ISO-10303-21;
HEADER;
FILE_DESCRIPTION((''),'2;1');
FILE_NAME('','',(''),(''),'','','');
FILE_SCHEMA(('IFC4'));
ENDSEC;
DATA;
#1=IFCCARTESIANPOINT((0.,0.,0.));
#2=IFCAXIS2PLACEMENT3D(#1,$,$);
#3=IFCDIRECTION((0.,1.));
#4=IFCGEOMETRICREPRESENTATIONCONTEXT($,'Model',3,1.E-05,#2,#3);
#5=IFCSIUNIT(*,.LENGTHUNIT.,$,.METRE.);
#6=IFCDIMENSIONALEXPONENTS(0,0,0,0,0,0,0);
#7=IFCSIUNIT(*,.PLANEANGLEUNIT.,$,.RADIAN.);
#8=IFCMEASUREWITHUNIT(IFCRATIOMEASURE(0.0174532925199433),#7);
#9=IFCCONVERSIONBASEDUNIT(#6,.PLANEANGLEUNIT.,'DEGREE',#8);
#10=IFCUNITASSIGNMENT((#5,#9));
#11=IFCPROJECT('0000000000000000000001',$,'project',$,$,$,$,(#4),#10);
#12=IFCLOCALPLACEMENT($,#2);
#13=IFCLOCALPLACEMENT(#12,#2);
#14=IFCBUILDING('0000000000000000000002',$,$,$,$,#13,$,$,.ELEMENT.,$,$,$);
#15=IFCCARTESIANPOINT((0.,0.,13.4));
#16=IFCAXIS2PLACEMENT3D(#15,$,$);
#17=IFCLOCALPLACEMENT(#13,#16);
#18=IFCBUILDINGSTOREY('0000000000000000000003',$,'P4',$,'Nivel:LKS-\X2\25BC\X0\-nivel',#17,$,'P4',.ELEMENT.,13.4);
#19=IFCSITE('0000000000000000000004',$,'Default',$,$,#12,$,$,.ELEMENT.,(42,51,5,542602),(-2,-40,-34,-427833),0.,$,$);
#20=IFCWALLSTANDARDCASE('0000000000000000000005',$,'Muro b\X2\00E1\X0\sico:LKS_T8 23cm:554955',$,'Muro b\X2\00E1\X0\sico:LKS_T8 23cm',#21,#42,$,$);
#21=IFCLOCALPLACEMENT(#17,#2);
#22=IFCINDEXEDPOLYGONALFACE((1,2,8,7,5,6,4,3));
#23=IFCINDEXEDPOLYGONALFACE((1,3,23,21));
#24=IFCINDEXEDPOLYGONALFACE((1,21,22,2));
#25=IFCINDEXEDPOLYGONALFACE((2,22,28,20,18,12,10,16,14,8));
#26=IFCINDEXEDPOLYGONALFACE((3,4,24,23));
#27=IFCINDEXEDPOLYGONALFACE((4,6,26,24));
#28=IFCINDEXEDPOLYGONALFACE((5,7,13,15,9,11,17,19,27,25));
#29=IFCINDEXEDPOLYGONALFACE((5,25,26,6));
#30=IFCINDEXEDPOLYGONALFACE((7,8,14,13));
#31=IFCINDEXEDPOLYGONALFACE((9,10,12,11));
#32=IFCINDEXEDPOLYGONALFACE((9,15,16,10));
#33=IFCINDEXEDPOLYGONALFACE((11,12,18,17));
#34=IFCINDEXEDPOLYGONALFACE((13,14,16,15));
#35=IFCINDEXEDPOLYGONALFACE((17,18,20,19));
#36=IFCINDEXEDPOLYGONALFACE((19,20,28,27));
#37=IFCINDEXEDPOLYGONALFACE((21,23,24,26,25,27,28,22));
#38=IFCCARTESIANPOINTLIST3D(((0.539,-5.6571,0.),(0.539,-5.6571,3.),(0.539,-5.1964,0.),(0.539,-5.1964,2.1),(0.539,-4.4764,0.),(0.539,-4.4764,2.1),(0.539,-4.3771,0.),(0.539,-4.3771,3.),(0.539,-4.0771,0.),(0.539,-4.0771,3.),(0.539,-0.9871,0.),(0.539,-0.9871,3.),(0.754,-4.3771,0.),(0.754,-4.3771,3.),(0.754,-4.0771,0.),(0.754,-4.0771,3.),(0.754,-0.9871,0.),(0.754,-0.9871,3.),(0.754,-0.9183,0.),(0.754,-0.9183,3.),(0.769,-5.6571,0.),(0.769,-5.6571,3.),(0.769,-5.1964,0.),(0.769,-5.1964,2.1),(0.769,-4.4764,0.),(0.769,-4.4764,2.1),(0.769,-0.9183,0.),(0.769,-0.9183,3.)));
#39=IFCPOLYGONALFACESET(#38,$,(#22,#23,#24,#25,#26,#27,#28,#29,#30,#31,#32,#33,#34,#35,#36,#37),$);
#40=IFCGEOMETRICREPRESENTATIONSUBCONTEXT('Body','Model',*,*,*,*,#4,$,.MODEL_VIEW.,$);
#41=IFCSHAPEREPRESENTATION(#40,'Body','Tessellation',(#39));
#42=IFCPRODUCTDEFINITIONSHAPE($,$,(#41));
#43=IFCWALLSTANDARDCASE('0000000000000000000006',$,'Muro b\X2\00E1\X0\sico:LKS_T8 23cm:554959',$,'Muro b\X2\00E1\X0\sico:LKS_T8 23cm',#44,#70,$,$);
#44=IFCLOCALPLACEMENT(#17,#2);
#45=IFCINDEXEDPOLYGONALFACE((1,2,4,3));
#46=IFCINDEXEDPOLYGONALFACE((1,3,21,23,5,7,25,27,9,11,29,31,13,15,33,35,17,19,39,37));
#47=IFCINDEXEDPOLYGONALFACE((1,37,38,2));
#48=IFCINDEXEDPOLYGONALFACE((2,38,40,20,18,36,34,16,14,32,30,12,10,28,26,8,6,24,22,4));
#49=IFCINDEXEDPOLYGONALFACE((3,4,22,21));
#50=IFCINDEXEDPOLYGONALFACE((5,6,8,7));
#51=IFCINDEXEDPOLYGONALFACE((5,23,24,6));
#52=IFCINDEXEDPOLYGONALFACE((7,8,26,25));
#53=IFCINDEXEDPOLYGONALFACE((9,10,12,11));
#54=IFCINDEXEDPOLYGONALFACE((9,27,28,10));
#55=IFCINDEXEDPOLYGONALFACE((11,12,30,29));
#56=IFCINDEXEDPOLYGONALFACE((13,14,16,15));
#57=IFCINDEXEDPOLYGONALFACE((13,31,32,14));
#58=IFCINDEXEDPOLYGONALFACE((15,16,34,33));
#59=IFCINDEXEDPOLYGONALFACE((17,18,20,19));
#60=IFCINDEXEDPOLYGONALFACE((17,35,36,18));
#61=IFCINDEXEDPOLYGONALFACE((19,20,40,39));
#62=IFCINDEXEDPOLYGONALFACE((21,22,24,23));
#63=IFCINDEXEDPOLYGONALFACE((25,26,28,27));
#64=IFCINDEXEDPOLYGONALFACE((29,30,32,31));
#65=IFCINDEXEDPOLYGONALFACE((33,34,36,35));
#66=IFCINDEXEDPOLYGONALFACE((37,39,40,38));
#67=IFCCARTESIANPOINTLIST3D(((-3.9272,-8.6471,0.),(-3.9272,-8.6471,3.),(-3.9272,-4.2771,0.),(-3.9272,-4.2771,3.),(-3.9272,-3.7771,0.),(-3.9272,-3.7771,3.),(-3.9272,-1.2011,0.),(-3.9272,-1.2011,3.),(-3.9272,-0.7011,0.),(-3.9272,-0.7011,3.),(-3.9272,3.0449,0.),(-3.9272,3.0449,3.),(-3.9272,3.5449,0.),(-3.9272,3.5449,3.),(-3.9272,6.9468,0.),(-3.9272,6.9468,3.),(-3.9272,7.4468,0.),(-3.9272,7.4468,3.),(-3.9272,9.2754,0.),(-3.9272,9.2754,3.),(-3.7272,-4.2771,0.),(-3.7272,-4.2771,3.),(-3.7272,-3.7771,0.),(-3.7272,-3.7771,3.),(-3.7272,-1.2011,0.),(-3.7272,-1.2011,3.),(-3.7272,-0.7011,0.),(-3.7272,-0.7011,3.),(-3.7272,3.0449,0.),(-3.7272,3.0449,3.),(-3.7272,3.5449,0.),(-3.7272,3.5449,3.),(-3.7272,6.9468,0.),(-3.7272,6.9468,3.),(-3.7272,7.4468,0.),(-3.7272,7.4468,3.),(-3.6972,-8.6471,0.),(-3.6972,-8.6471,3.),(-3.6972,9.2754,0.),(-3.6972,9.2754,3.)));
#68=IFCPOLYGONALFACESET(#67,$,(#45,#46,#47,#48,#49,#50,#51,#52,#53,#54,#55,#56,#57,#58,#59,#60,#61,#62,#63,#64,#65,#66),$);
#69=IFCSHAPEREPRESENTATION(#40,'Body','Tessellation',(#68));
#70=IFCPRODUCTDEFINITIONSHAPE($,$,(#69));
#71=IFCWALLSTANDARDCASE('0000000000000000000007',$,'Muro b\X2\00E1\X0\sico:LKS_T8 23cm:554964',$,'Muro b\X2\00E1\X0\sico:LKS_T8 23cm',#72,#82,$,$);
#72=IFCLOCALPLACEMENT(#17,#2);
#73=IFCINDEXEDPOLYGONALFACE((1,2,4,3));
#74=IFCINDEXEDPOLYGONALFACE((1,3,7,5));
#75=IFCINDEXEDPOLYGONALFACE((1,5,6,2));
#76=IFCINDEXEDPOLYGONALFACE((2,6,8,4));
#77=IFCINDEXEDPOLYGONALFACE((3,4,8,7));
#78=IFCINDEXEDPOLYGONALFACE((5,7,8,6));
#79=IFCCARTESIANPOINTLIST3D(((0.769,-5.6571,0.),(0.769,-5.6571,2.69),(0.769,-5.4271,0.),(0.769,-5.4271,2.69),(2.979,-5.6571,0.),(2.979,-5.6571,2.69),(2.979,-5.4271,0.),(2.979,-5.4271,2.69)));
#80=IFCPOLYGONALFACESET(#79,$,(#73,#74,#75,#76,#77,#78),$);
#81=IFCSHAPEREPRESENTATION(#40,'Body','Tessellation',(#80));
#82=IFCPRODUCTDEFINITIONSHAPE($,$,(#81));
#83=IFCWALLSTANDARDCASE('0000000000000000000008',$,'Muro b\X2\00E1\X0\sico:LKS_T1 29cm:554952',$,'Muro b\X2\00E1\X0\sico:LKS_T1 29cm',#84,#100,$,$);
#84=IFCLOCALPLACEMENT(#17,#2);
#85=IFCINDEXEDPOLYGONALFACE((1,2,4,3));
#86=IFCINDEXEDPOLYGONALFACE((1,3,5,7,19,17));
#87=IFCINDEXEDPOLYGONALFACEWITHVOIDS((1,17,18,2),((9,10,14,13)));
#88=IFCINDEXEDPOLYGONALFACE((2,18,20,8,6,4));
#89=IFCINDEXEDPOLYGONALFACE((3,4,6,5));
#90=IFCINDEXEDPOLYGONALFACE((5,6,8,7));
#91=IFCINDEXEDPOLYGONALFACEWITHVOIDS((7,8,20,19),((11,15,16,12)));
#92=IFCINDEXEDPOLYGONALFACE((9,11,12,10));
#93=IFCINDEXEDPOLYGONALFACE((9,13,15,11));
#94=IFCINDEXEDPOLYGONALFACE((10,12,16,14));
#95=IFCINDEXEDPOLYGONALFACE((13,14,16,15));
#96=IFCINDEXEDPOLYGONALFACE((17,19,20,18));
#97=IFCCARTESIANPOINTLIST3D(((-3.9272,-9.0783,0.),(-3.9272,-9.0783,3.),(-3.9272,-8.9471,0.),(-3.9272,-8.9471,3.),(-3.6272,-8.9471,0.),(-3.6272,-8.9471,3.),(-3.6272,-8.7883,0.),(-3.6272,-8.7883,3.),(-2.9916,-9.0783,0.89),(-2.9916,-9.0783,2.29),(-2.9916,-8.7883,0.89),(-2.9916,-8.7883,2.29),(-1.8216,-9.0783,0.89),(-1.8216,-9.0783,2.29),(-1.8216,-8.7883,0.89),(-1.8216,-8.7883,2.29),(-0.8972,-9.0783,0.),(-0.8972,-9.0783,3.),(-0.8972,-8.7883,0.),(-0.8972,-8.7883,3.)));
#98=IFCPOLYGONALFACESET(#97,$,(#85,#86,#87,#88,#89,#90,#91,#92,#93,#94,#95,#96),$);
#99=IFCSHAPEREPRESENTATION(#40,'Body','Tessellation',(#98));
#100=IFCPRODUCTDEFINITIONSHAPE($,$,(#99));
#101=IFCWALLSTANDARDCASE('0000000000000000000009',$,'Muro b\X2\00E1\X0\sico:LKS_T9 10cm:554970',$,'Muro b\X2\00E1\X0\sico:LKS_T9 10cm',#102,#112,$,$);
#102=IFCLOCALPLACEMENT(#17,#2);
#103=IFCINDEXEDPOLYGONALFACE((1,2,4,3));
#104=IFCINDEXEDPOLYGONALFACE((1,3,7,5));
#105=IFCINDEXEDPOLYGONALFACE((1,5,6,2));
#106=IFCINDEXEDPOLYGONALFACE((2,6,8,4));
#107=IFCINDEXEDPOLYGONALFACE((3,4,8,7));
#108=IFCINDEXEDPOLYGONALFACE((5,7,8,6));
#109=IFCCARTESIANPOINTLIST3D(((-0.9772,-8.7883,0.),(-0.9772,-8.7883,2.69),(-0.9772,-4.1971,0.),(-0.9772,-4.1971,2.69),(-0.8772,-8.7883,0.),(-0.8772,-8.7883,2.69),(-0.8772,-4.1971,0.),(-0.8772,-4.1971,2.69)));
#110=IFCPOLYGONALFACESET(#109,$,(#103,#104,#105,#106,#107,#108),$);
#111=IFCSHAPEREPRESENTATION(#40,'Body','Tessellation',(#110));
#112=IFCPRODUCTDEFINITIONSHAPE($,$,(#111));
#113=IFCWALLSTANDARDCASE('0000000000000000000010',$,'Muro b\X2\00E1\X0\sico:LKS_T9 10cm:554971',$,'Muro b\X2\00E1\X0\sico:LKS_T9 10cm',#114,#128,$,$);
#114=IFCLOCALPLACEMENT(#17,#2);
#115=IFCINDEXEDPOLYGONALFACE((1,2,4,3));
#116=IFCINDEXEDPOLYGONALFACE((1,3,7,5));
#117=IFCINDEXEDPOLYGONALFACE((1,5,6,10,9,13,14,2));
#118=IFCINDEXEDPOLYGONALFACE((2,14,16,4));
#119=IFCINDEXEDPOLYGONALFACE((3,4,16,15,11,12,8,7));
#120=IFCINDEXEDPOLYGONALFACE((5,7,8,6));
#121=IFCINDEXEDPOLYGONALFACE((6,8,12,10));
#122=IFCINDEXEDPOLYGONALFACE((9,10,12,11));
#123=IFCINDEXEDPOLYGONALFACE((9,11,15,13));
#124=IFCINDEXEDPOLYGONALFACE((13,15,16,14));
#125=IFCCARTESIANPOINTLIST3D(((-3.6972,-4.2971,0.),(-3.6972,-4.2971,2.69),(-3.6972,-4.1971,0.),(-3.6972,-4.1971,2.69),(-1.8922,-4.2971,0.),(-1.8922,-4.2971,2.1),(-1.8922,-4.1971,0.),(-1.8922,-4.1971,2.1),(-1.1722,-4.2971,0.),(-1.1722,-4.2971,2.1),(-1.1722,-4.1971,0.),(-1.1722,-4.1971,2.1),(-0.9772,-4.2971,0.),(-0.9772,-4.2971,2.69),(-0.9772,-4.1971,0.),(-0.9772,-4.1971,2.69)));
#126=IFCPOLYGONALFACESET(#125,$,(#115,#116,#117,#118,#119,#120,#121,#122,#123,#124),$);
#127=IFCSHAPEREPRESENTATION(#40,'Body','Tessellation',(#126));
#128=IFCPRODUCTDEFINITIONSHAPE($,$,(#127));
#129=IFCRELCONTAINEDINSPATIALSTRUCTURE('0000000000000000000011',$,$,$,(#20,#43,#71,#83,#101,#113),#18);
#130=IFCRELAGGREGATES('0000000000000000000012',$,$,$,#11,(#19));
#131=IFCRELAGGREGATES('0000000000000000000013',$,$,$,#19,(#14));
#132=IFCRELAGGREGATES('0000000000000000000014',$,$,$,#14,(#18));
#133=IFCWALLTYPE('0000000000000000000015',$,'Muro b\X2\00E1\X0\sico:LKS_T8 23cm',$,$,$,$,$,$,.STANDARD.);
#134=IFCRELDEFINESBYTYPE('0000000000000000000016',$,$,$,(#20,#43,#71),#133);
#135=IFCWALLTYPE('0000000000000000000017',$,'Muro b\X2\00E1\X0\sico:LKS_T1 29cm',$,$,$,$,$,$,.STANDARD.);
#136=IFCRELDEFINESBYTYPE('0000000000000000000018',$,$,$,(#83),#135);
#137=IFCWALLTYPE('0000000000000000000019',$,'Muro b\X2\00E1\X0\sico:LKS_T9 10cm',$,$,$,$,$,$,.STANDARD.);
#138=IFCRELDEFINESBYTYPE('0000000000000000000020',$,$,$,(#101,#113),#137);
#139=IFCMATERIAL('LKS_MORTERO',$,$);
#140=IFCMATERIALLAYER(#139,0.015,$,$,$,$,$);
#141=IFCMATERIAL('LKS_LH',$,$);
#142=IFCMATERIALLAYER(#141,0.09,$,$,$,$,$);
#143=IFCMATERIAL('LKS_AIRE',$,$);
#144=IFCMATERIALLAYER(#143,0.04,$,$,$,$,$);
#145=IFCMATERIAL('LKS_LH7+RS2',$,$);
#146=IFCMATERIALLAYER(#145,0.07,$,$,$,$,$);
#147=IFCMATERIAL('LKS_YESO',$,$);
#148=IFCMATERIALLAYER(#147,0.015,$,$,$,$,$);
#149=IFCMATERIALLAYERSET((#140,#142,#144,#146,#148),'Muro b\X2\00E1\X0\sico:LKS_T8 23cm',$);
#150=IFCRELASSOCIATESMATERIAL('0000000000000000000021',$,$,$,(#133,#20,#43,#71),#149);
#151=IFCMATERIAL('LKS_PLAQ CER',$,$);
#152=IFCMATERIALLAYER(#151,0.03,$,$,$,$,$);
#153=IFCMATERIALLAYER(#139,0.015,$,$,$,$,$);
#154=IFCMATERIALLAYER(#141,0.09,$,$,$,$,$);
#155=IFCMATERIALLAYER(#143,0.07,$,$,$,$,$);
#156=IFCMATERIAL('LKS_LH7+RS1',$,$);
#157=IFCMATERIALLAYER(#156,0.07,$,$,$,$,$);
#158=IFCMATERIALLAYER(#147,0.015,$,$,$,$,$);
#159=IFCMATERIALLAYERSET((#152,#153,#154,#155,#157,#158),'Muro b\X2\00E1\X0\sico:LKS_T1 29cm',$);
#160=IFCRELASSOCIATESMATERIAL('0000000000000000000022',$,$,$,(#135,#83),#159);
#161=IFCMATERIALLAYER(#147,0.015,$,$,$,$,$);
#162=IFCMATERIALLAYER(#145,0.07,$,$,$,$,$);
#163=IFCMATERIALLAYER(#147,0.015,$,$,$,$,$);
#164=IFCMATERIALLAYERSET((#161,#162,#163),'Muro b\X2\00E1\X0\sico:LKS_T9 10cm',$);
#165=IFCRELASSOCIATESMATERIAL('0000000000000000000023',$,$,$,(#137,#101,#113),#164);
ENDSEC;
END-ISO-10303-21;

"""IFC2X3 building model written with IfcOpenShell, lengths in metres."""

from ifc_helpers import new_model, entity, si_unit, converted_unit, direction, frame, frame_2d, origin, place, context, subcontext, project, spatial, polyline, rectangle, extrude, clip, bounded_halfspace, material, layer, layer_set, layer_usage, type_object, element, save


model = new_model("IFC2X3")

# Units and contexts
model_context = context("Model", 3, precision=1e-05, world=origin(), true_north=direction((0.0, 1.0)))
body_context = subcontext(model_context, "Body", "Model", "MODEL_VIEW")
ifc_project = project(units=[si_unit("LENGTHUNIT", "METRE"), converted_unit("PLANEANGLEUNIT", "DEGREE", entity("IfcRatioMeasure", 0.0174532925199433), si_unit("PLANEANGLEUNIT", "RADIAN"), dimensions=[0, 0, 0, 0, 0, 0, 0])], contexts=[model_context])

# Site, building, storey
site_placement = place(None, origin())
site = spatial("IfcSite", under=ifc_project, at=site_placement, Name="Default", CompositionType="ELEMENT", RefLatitude=(42, 51, 5, 542602), RefLongitude=(-2, -40, -34, -427833), RefElevation=0.0)
building_placement = place(site_placement, origin())
building = spatial("IfcBuilding", under=site, at=building_placement, CompositionType="ELEMENT")
storey_placement = place(building_placement, frame((0.0, 0.0, 13.4)))
storey = spatial("IfcBuildingStorey", under=building, at=storey_placement, Name="P4", ObjectType="Nivel:LKS-▼-nivel", LongName="P4", CompositionType="ELEMENT", Elevation=13.4)

# Shared definitions
ifc_material_1 = material(Name="LKS_MORTERO")
ifc_layer_1 = layer(ifc_material_1, 0.015)
ifc_material_2 = material(Name="LKS_LH")
ifc_layer_2 = layer(ifc_material_2, 0.09)
ifc_material_3 = material(Name="LKS_AIRE")
ifc_layer_3 = layer(ifc_material_3, 0.04)
ifc_material_4 = material(Name="LKS_LH7+RS2")
ifc_layer_4 = layer(ifc_material_4, 0.07)
ifc_material_5 = material(Name="LKS_YESO")
ifc_layer_5 = layer(ifc_material_5, 0.015)
ifc_layer_set_1 = layer_set([ifc_layer_1, ifc_layer_2, ifc_layer_3, ifc_layer_4, ifc_layer_5], Name="Muro básico:LKS_T8 23cm")
wall_type_1 = type_object("IfcWallType", Name="Muro básico:LKS_T8 23cm", PredefinedType="STANDARD", material=ifc_layer_set_1)

# Walls, openings
ifc_layer_usage_1 = layer_usage(ifc_layer_set_1, "AXIS2", "POSITIVE", -0.115)
wall_1_placement = place(storey_placement, frame((0.654, -5.6571, 0.0), z_axis=(0.0, 0.0, 1.0), x_axis=(0.0, 1.0, 0.0)))
wall_1 = element("IfcWallStandardCase", 1, at=wall_1_placement, inside=storey, type_object=wall_type_1, material=ifc_layer_usage_1, Name="Muro básico:LKS_T8 23cm:554955", ObjectType="Muro básico:LKS_T8 23cm", context=body_context, shape_type="Clipping", body=[
    clip(clip(extrude(rectangle(XDim=4.7389, YDim=0.23, at=frame_2d((2.3694, 0.0), x_axis=(-1.0, 0.0))), origin(), (0.0, 0.0, 1.0), 3.0), bounded_halfspace(frame((4.67, -0.1, 0.0), z_axis=(0.0, -1.0, 0.0), x_axis=(0.0, 0.0, -1.0)), True, frame((4.67, -0.1, 0.0), z_axis=(0.0, -1.0, 0.0), x_axis=(0.0, 0.0, -1.0)), polyline([(0.0, 0.0), (0.0, 0.0689), (-1.5, 0.0689), (-3.0, 0.0689), (-3.0, 0.0), (0.0, 0.0)]))), bounded_halfspace(frame((4.67, -0.1, 3.0), z_axis=(-1.0, 0.0, 0.0), x_axis=(0.0, 0.0, -1.0)), True, frame((4.67, -0.1, 3.0), z_axis=(-1.0, 0.0, 0.0), x_axis=(0.0, 0.0, -1.0)), polyline([(0.0, 0.0), (0.0, -0.015), (0.0, -0.215), (3.0, -0.215), (3.0, 0.0), (0.0, 0.0)]))),
])
opening_1_placement = place(storey_placement, frame((0.654, -5.6571, 0.0), z_axis=(0.0, 0.0, 1.0), x_axis=(0.0, 1.0, 0.0)))
element("IfcOpeningElement", 2, at=opening_1_placement, cuts=wall_1, ObjectType="Opening", context=body_context, shape_type="SweptSolid", body=[
    extrude(rectangle(XDim=3.0, YDim=0.215, at=frame_2d((0.234, 0.0215), x_axis=(1.0, 0.0))), frame((1.28, -0.014, 1.734), z_axis=(1.0, 0.0, 0.0), x_axis=(0.0, 0.0, -1.0)), (0.0, 0.0, 1.0), 0.3),
])
opening_2_placement = place(wall_1_placement, frame((0.4608, -0.115, 0.0)))
element("IfcOpeningElement", 3, at=opening_2_placement, cuts=wall_1, ObjectType="Opening", context=body_context, shape_type="SweptSolid", body=[
    extrude(rectangle(XDim=2.1, YDim=0.72, at=frame_2d((1.05, 0.36), x_axis=(1.0, 0.0))), frame((0.0, 0.0, 0.0), z_axis=(0.0, 1.0, 0.0), x_axis=(0.0, 0.0, 1.0)), (0.0, 0.0, 1.0), 0.23),
])
ifc_layer_usage_2 = layer_usage(ifc_layer_set_1, "AXIS2", "NEGATIVE", 0.115)
wall_2_placement = place(storey_placement, frame((-3.8122, -8.6471, 0.0), z_axis=(0.0, 0.0, 1.0), x_axis=(0.0, 1.0, 0.0)))
wall_2 = element("IfcWallStandardCase", 4, at=wall_2_placement, inside=storey, type_object=wall_type_1, material=ifc_layer_usage_2, Name="Muro básico:LKS_T8 23cm:554959", ObjectType="Muro básico:LKS_T8 23cm", context=body_context, shape_type="Clipping", body=[
    clip(extrude(rectangle(XDim=17.9225, YDim=0.23, at=frame_2d((8.9613, 0.0), x_axis=(-1.0, 0.0))), origin(), (0.0, 0.0, 1.0), 3.0), bounded_halfspace(frame((0.0, -0.115, 0.0), z_axis=(1.0, 0.0, 0.0), x_axis=(0.0, 0.0, -1.0)), True, frame((0.0, -0.115, 0.0), z_axis=(1.0, 0.0, 0.0), x_axis=(0.0, 0.0, -1.0)), polyline([(0.0, 0.0), (0.0, 0.23), (-2.67, 0.23), (-3.0, 0.23), (-3.0, 0.0), (0.0, 0.0)]))),
])
opening_3_placement = place(storey_placement, frame((-3.8122, -8.6471, 0.0), z_axis=(0.0, 0.0, 1.0), x_axis=(0.0, 1.0, 0.0)))
element("IfcOpeningElement", 5, at=opening_3_placement, cuts=wall_2, ObjectType="Opening", context=body_context, shape_type="SweptSolid", body=[
    extrude(rectangle(XDim=3.0, YDim=0.2, at=frame_2d((0.39, 0.0), x_axis=(1.0, 0.0))), frame((4.37, 0.015, 1.89), z_axis=(1.0, 0.0, 0.0), x_axis=(0.0, 0.0, -1.0)), (0.0, 0.0, 1.0), 0.5),
])
opening_4_placement = place(storey_placement, frame((-3.8122, -8.6471, 0.0), z_axis=(0.0, 0.0, 1.0), x_axis=(0.0, 1.0, 0.0)))
element("IfcOpeningElement", 6, at=opening_4_placement, cuts=wall_2, ObjectType="Opening", context=body_context, shape_type="SweptSolid", body=[
    extrude(rectangle(XDim=3.0, YDim=0.2, at=frame_2d((0.39, 0.0), x_axis=(1.0, 0.0))), frame((7.446, 0.015, 1.89), z_axis=(1.0, 0.0, 0.0), x_axis=(0.0, 0.0, -1.0)), (0.0, 0.0, 1.0), 0.5),
])
opening_5_placement = place(storey_placement, frame((-3.8122, -8.6471, 0.0), z_axis=(0.0, 0.0, 1.0), x_axis=(0.0, 1.0, 0.0)))
element("IfcOpeningElement", 7, at=opening_5_placement, cuts=wall_2, ObjectType="Opening", context=body_context, shape_type="SweptSolid", body=[
    extrude(rectangle(XDim=3.0, YDim=0.2, at=frame_2d((0.39, 0.0), x_axis=(1.0, 0.0))), frame((11.692, 0.015, 1.89), z_axis=(1.0, 0.0, 0.0), x_axis=(0.0, 0.0, -1.0)), (0.0, 0.0, 1.0), 0.5),
])
opening_6_placement = place(storey_placement, frame((-3.8122, -8.6471, 0.0), z_axis=(0.0, 0.0, 1.0), x_axis=(0.0, 1.0, 0.0)))
element("IfcOpeningElement", 8, at=opening_6_placement, cuts=wall_2, ObjectType="Opening", context=body_context, shape_type="SweptSolid", body=[
    extrude(rectangle(XDim=3.0, YDim=0.2, at=frame_2d((0.39, 0.0), x_axis=(1.0, 0.0))), frame((15.5939, 0.015, 1.89), z_axis=(1.0, 0.0, 0.0), x_axis=(0.0, 0.0, -1.0)), (0.0, 0.0, 1.0), 0.5),
])

# Wall
ifc_layer_usage_3 = layer_usage(ifc_layer_set_1, "AXIS2", "POSITIVE", -0.115)
wall_3_placement = place(storey_placement, frame((2.979, -5.5421, 0.0), z_axis=(0.0, 0.0, 1.0), x_axis=(-1.0, 0.0, 0.0)))
element("IfcWallStandardCase", 9, at=wall_3_placement, inside=storey, type_object=wall_type_1, material=ifc_layer_usage_3, Name="Muro básico:LKS_T8 23cm:554964", ObjectType="Muro básico:LKS_T8 23cm", context=body_context, shape_type="SweptSolid", body=[
    extrude(rectangle(XDim=2.21, YDim=0.23, at=frame_2d((1.105, 0.0), x_axis=(-1.0, 0.0))), origin(), (0.0, 0.0, 1.0), 2.69),
])

# Wall, opening
ifc_material_6 = material(Name="LKS_PLAQ CER")
ifc_layer_6 = layer(ifc_material_6, 0.03)
ifc_layer_7 = layer(ifc_material_1, 0.015)
ifc_layer_8 = layer(ifc_material_2, 0.09)
ifc_layer_9 = layer(ifc_material_3, 0.07)
ifc_material_7 = material(Name="LKS_LH7+RS1")
ifc_layer_10 = layer(ifc_material_7, 0.07)
ifc_layer_11 = layer(ifc_material_5, 0.015)
ifc_layer_set_2 = layer_set([ifc_layer_6, ifc_layer_7, ifc_layer_8, ifc_layer_9, ifc_layer_10, ifc_layer_11], Name="Muro básico:LKS_T1 29cm")
ifc_layer_usage_4 = layer_usage(ifc_layer_set_2, "AXIS2", "POSITIVE", -0.145)
wall_type_2 = type_object("IfcWallType", Name="Muro básico:LKS_T1 29cm", PredefinedType="STANDARD", material=ifc_layer_set_2)
wall_4_placement = place(storey_placement, frame((-3.9272, -8.9333, 0.0)))
wall_4 = element("IfcWallStandardCase", 10, at=wall_4_placement, inside=storey, type_object=wall_type_2, material=ifc_layer_usage_4, Name="Muro básico:LKS_T1 29cm:554952", ObjectType="Muro básico:LKS_T1 29cm", context=body_context, shape_type="Clipping", body=[
    clip(clip(extrude(rectangle(XDim=3.03, YDim=0.29, at=frame_2d((1.515, 0.0), x_axis=(-1.0, 0.0))), origin(), (0.0, 0.0, 1.0), 3.0), bounded_halfspace(frame((0.3, -0.0139, 0.0), z_axis=(1.0, 0.0, 0.0), x_axis=(0.0, 0.0, -1.0)), True, frame((0.3, -0.0139, 0.0), z_axis=(1.0, 0.0, 0.0), x_axis=(0.0, 0.0, -1.0)), polyline([(0.0, 0.0), (0.0, 0.1589), (-3.0, 0.1589), (-3.0, 0.0), (-2.67, 0.0), (0.0, 0.0)]))), bounded_halfspace(frame((0.3, -0.0139, 3.0), z_axis=(0.0, -1.0, 0.0), x_axis=(0.0, 0.0, -1.0)), True, frame((0.3, -0.0139, 3.0), z_axis=(0.0, -1.0, 0.0), x_axis=(0.0, 0.0, -1.0)), polyline([(0.0, 0.0), (0.0, -0.3), (0.33, -0.3), (3.0, -0.3), (3.0, 0.0), (0.33, 0.0), (0.0, 0.0)]))),
])
opening_7_placement = place(wall_4_placement, frame((0.9356, -0.145, 0.89)))
element("IfcOpeningElement", 11, at=opening_7_placement, cuts=wall_4, ObjectType="Opening", context=body_context, shape_type="SweptSolid", body=[
    extrude(rectangle(XDim=1.4, YDim=1.17, at=frame_2d((0.7, 0.585), x_axis=(1.0, 0.0))), frame((0.0, 0.0, 0.0), z_axis=(0.0, 1.0, 0.0), x_axis=(0.0, 0.0, 1.0)), (0.0, 0.0, 1.0), 0.29),
])

# Wall
ifc_layer_12 = layer(ifc_material_5, 0.015)
ifc_layer_13 = layer(ifc_material_4, 0.07)
ifc_layer_14 = layer(ifc_material_5, 0.015)
ifc_layer_set_3 = layer_set([ifc_layer_12, ifc_layer_13, ifc_layer_14], Name="Muro básico:LKS_T9 10cm")
ifc_layer_usage_5 = layer_usage(ifc_layer_set_3, "AXIS2", "POSITIVE", -0.05)
wall_type_3 = type_object("IfcWallType", Name="Muro básico:LKS_T9 10cm", PredefinedType="STANDARD", material=ifc_layer_set_3)
wall_5_placement = place(storey_placement, frame((-0.9272, -8.7883, 0.0), z_axis=(0.0, 0.0, 1.0), x_axis=(0.0, 1.0, 0.0)))
element("IfcWallStandardCase", 12, at=wall_5_placement, inside=storey, type_object=wall_type_3, material=ifc_layer_usage_5, Name="Muro básico:LKS_T9 10cm:554970", ObjectType="Muro básico:LKS_T9 10cm", context=body_context, shape_type="SweptSolid", body=[
    extrude(rectangle(XDim=4.5911, YDim=0.1, at=frame_2d((2.2956, 0.0), x_axis=(-1.0, 0.0))), origin(), (0.0, 0.0, 1.0), 2.69),
])

# Wall, opening
ifc_layer_usage_6 = layer_usage(ifc_layer_set_3, "AXIS2", "POSITIVE", -0.05)
wall_6_placement = place(storey_placement, frame((-0.9772, -4.2471, 0.0), z_axis=(0.0, 0.0, 1.0), x_axis=(-1.0, 0.0, 0.0)))
wall_6 = element("IfcWallStandardCase", 13, at=wall_6_placement, inside=storey, type_object=wall_type_3, material=ifc_layer_usage_6, Name="Muro básico:LKS_T9 10cm:554971", ObjectType="Muro básico:LKS_T9 10cm", context=body_context, shape_type="SweptSolid", body=[
    extrude(rectangle(XDim=2.72, YDim=0.1, at=frame_2d((1.36, 0.0), x_axis=(-1.0, 0.0))), origin(), (0.0, 0.0, 1.0), 2.69),
])
opening_8_placement = place(wall_6_placement, frame((0.195, -0.05, 0.0)))
element("IfcOpeningElement", 14, at=opening_8_placement, cuts=wall_6, ObjectType="Opening", context=body_context, shape_type="SweptSolid", body=[
    extrude(rectangle(XDim=2.1, YDim=0.72, at=frame_2d((1.05, 0.36), x_axis=(1.0, 0.0))), frame((0.0, 0.0, 0.0), z_axis=(0.0, 1.0, 0.0), x_axis=(0.0, 0.0, 1.0)), (0.0, 0.0, 1.0), 0.1),
])

save(model, "model.ifc")
